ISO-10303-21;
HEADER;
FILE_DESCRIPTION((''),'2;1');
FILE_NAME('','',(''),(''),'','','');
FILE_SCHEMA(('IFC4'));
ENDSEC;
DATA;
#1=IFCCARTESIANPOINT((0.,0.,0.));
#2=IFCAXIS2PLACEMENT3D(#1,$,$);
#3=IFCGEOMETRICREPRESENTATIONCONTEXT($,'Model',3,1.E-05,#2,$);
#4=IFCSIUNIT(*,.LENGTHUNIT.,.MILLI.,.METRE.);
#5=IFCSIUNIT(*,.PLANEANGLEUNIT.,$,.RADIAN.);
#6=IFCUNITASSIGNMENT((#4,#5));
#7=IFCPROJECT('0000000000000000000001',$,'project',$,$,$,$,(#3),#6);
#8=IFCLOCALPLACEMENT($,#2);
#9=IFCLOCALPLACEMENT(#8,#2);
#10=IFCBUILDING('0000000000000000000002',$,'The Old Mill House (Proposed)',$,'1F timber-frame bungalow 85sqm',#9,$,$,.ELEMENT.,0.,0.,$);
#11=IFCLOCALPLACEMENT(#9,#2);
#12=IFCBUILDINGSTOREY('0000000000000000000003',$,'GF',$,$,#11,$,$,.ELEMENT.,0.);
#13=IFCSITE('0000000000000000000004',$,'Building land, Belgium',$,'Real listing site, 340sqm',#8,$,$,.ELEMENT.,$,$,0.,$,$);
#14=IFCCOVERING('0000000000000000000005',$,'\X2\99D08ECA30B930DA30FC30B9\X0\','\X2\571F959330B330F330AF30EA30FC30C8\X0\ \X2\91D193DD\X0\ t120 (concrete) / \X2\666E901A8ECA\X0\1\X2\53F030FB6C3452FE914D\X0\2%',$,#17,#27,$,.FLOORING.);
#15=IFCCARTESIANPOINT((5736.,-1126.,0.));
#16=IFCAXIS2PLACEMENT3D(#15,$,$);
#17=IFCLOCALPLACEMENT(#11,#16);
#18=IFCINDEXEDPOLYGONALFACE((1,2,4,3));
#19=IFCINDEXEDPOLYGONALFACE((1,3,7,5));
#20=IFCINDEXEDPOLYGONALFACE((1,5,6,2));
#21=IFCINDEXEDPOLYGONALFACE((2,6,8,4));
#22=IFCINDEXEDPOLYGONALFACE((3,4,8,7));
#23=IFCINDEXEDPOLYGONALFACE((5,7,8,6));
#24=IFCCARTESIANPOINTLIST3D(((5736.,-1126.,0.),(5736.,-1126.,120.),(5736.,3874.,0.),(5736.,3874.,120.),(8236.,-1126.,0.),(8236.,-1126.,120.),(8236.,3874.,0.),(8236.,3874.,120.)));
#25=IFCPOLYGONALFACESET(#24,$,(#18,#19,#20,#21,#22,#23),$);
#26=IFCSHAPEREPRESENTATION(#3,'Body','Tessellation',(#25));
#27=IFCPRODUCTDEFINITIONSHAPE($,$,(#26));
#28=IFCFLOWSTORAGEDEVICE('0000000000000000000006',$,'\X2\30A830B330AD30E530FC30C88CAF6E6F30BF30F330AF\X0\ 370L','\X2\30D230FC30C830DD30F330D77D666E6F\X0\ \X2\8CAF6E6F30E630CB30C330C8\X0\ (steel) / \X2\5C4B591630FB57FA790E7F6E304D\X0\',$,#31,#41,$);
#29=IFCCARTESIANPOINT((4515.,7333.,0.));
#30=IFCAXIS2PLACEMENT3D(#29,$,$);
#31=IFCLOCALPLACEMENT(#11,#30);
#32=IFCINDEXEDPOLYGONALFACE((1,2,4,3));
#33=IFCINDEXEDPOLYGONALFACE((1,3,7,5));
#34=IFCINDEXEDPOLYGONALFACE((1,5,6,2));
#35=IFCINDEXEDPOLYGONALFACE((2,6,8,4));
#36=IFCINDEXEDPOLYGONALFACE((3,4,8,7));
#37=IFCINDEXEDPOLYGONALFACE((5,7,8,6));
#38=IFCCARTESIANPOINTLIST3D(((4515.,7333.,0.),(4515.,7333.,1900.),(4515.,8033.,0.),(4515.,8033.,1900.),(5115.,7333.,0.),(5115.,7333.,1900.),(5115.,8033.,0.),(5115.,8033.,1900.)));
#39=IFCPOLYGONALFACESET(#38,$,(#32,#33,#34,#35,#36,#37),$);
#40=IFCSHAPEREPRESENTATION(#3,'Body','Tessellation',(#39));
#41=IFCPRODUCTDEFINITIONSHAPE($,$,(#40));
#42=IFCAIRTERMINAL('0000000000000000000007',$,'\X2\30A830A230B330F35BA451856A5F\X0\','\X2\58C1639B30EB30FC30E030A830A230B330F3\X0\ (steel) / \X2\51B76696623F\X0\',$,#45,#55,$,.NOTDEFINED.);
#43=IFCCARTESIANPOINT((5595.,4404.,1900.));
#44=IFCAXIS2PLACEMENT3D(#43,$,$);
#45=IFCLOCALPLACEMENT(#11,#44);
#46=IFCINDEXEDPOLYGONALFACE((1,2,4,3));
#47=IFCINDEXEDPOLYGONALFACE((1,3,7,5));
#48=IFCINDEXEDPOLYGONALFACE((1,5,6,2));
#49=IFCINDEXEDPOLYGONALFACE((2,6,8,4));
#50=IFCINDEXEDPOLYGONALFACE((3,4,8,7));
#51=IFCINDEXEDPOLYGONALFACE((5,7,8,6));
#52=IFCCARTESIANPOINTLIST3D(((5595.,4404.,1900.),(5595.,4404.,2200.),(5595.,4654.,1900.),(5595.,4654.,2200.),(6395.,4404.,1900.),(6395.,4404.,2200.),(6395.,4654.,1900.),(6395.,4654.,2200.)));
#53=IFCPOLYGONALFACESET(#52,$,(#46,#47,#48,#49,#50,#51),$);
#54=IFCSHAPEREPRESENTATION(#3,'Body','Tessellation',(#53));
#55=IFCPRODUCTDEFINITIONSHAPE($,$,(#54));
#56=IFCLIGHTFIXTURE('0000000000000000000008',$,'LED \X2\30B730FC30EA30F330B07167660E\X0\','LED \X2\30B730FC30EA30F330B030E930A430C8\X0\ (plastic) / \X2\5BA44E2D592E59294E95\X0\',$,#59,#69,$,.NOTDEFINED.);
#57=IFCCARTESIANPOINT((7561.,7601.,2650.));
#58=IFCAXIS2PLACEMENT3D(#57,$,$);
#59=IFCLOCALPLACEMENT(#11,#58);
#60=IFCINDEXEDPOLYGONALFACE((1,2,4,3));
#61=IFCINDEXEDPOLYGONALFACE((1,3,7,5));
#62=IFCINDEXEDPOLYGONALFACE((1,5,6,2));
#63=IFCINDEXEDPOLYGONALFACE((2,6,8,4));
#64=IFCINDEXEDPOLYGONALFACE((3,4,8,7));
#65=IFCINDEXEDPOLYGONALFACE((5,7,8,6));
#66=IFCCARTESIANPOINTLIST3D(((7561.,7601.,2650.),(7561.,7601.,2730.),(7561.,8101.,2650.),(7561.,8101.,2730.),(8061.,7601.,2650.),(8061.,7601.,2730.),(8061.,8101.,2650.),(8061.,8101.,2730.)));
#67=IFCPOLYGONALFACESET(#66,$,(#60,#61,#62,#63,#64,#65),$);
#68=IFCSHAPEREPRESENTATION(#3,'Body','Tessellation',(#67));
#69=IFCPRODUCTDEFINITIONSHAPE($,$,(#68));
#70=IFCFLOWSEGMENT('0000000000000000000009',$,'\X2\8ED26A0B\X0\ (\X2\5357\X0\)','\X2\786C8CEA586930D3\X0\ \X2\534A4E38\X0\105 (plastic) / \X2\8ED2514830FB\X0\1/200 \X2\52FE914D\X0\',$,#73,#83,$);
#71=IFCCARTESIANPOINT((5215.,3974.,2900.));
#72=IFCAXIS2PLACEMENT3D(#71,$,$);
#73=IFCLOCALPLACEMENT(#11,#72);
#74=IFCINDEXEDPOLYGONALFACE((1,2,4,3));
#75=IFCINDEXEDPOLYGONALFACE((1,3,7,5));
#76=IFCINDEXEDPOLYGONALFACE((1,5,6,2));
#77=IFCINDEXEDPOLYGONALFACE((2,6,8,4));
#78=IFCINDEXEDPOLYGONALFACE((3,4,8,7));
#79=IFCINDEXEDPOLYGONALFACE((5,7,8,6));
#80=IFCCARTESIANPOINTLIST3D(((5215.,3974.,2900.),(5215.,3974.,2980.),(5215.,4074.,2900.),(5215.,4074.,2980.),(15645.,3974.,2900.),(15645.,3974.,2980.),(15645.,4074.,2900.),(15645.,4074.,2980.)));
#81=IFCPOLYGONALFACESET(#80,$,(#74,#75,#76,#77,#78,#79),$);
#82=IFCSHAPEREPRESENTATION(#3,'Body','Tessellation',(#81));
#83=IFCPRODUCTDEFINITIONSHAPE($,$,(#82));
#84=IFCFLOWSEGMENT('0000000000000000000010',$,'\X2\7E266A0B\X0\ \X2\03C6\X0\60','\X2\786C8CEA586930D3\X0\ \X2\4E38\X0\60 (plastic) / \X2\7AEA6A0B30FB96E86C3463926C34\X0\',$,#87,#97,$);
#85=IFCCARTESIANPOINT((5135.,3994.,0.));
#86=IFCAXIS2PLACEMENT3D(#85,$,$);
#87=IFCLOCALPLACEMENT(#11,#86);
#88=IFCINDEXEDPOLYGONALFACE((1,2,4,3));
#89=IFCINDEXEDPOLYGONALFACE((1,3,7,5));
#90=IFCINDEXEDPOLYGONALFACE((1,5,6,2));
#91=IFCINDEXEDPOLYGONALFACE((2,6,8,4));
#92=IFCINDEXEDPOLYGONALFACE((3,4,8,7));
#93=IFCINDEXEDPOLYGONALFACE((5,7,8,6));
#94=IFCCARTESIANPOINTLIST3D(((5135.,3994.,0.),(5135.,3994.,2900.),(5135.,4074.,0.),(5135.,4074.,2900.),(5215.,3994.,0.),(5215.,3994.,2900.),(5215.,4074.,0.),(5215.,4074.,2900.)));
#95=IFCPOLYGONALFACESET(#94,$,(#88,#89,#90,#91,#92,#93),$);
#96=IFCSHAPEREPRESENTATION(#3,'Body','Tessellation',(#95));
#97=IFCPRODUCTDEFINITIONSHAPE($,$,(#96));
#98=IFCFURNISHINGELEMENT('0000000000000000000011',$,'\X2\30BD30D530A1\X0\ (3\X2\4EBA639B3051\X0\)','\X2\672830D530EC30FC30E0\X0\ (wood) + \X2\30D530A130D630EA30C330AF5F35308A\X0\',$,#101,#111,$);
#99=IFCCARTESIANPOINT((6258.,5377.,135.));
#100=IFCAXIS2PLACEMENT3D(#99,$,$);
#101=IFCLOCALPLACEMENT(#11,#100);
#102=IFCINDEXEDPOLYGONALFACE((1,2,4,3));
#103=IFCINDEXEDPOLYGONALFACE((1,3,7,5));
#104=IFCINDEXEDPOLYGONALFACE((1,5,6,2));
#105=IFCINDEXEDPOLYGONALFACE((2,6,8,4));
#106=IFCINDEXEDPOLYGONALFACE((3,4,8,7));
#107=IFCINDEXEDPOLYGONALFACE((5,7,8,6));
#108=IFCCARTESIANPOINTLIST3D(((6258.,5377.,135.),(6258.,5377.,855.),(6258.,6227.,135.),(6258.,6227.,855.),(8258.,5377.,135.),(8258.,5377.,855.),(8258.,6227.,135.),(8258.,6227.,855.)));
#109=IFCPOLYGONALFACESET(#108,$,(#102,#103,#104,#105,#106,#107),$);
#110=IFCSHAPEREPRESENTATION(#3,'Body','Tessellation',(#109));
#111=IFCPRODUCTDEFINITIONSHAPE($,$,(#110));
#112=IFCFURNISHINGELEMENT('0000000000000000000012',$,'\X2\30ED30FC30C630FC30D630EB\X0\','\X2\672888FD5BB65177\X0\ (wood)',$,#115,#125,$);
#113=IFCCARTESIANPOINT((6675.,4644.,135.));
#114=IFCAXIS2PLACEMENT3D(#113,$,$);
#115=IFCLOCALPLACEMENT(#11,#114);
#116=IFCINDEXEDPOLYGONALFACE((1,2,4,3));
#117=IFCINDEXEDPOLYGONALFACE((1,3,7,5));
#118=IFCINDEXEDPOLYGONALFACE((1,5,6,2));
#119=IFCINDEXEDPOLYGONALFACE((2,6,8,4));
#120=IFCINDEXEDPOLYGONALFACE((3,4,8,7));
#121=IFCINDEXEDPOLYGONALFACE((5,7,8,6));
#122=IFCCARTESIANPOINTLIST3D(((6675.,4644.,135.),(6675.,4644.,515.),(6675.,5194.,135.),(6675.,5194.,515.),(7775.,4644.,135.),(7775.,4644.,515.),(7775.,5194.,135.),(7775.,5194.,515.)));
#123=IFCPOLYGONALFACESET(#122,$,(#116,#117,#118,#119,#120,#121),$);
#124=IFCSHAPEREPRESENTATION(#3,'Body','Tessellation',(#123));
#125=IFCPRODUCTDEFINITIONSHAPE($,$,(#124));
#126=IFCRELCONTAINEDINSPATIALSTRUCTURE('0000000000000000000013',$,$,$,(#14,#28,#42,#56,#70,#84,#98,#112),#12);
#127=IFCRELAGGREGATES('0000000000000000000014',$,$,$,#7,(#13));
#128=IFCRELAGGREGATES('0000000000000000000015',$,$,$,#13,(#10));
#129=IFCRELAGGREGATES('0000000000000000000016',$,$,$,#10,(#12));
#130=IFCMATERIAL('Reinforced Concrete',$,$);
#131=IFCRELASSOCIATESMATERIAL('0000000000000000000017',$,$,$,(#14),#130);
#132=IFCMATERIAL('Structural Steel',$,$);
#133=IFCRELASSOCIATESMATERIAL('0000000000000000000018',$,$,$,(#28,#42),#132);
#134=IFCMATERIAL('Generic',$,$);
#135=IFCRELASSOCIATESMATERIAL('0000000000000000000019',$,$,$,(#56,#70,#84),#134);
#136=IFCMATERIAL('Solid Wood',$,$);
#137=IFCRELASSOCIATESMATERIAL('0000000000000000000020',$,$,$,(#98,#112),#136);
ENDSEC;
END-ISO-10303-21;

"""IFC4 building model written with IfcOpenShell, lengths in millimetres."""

from ifc_helpers import new_model, si_unit, frame, frame_2d, origin, place, context, project, spatial, rectangle, extrude, material, element, save


model = new_model("IFC4")

# Units and contexts
model_context = context("Model", 3, precision=1e-05, world=origin())
ifc_project = project(units=[si_unit("LENGTHUNIT", "METRE", prefix="MILLI"), si_unit("PLANEANGLEUNIT", "RADIAN")], contexts=[model_context])

# Site, building, storey
site_placement = place(None, origin())
site = spatial("IfcSite", under=ifc_project, at=site_placement, Name="Building land, Belgium", ObjectType="Real listing site, 340sqm", CompositionType="ELEMENT", RefElevation=0.0)
building_placement = place(site_placement, origin())
building = spatial("IfcBuilding", under=site, at=building_placement, Name="The Old Mill House (Proposed)", ObjectType="1F timber-frame bungalow 85sqm", CompositionType="ELEMENT", ElevationOfRefHeight=0.0, ElevationOfTerrain=0.0)
storey_placement = place(building_placement, origin())
storey = spatial("IfcBuildingStorey", under=building, at=storey_placement, Name="GF", CompositionType="ELEMENT", Elevation=0.0)

# Shared definitions
ifc_material_1 = material(Name="Solid Wood")

# Shared definitions
ifc_material_2 = material(Name="Reinforced Concrete")

# Shared definitions
ifc_material_3 = material(Name="Structural Steel")

# Covering
ifc_material_4 = material(Name="Generic")
covering_1_placement = place(storey_placement, frame((5736.0, -1126.0, 0.0)))
element("IfcCovering", 1, at=covering_1_placement, inside=storey, material=ifc_material_2, Name="駐車スペース", Description="土間コンクリート 金鏝 t120 (concrete) / 普通車1台・水勾配2%", PredefinedType="FLOORING", context=model_context, shape_type="SweptSolid", body=[
    extrude(rectangle(XDim=2500.0, YDim=5000.0, at=frame_2d((1250.0, 2500.0))), frame((5736.0, -1126.0, 0.0)), (0.0, 0.0, 1.0), 120.0),
])

# Flow storage device
flow_storage_device_placement = place(storey_placement, frame((4515.0, 7333.0, 0.0)))
element("IfcFlowStorageDevice", 2, at=flow_storage_device_placement, inside=storey, material=ifc_material_3, Name="エコキュート貯湯タンク 370L", Description="ヒートポンプ給湯 貯湯ユニット (steel) / 屋外・基礎置き", context=model_context, shape_type="SweptSolid", body=[
    extrude(rectangle(XDim=600.0, YDim=700.0, at=frame_2d((300.0, 350.0))), frame((4515.0, 7333.0, 0.0)), (0.0, 0.0, 1.0), 1900.0),
])

# Air terminal
air_terminal_placement = place(storey_placement, frame((5595.0, 4404.0, 1900.0)))
element("IfcAirTerminal", 3, at=air_terminal_placement, inside=storey, material=ifc_material_3, Name="エアコン室内機", Description="壁掛ルームエアコン (steel) / 冷暖房", PredefinedType="NOTDEFINED", context=model_context, shape_type="SweptSolid", body=[
    extrude(rectangle(XDim=800.0, YDim=250.0, at=frame_2d((400.0, 125.0))), frame((5595.0, 4404.0, 1900.0)), (0.0, 0.0, 1.0), 300.0),
])

# Light fixture
light_fixture_placement = place(storey_placement, frame((7561.0, 7601.0, 2650.0)))
element("IfcLightFixture", 4, at=light_fixture_placement, inside=storey, material=ifc_material_4, Name="LED シーリング照明", Description="LED シーリングライト (plastic) / 室中央天井", PredefinedType="NOTDEFINED", context=model_context, shape_type="SweptSolid", body=[
    extrude(rectangle(XDim=500.0, YDim=500.0, at=frame_2d((250.0, 250.0))), frame((7561.0, 7601.0, 2650.0)), (0.0, 0.0, 1.0), 80.0),
])

# Flow segments
flow_segment_1_placement = place(storey_placement, frame((5215.0, 3974.0, 2900.0)))
element("IfcFlowSegment", 5, at=flow_segment_1_placement, inside=storey, material=ifc_material_4, Name="軒樋 (南)", Description="硬質塩ビ 半丸105 (plastic) / 軒先・1/200 勾配", context=model_context, shape_type="SweptSolid", body=[
    extrude(rectangle(XDim=10430.0, YDim=100.0, at=frame_2d((5215.0, 50.0))), frame((5215.0, 3974.0, 2900.0)), (0.0, 0.0, 1.0), 80.0),
])
flow_segment_2_placement = place(storey_placement, frame((5135.0, 3994.0, 0.0)))
element("IfcFlowSegment", 6, at=flow_segment_2_placement, inside=storey, material=ifc_material_4, Name="縦樋 φ60", Description="硬質塩ビ 丸60 (plastic) / 竪樋・雨水排水", context=model_context, shape_type="SweptSolid", body=[
    extrude(rectangle(XDim=80.0, YDim=80.0, at=frame_2d((40.0, 40.0))), frame((5135.0, 3994.0, 0.0)), (0.0, 0.0, 1.0), 2900.0),
])

# Furnishing elements
furnishing_1_placement = place(storey_placement, frame((6258.0, 5377.0, 135.0)))
element("IfcFurnishingElement", 7, at=furnishing_1_placement, inside=storey, material=ifc_material_1, Name="ソファ (3人掛け)", Description="木フレーム (wood) + ファブリック張り", context=model_context, shape_type="SweptSolid", body=[
    extrude(rectangle(XDim=2000.0, YDim=850.0, at=frame_2d((1000.0, 425.0))), frame((6258.0, 5377.0, 135.0)), (0.0, 0.0, 1.0), 720.0),
])
furnishing_2_placement = place(storey_placement, frame((6675.0, 4644.0, 135.0)))
element("IfcFurnishingElement", 8, at=furnishing_2_placement, inside=storey, material=ifc_material_1, Name="ローテーブル", Description="木製家具 (wood)", context=model_context, shape_type="SweptSolid", body=[
    extrude(rectangle(XDim=1100.0, YDim=550.0, at=frame_2d((550.0, 275.0))), frame((6675.0, 4644.0, 135.0)), (0.0, 0.0, 1.0), 380.0),
])

save(model, "model.ifc")
